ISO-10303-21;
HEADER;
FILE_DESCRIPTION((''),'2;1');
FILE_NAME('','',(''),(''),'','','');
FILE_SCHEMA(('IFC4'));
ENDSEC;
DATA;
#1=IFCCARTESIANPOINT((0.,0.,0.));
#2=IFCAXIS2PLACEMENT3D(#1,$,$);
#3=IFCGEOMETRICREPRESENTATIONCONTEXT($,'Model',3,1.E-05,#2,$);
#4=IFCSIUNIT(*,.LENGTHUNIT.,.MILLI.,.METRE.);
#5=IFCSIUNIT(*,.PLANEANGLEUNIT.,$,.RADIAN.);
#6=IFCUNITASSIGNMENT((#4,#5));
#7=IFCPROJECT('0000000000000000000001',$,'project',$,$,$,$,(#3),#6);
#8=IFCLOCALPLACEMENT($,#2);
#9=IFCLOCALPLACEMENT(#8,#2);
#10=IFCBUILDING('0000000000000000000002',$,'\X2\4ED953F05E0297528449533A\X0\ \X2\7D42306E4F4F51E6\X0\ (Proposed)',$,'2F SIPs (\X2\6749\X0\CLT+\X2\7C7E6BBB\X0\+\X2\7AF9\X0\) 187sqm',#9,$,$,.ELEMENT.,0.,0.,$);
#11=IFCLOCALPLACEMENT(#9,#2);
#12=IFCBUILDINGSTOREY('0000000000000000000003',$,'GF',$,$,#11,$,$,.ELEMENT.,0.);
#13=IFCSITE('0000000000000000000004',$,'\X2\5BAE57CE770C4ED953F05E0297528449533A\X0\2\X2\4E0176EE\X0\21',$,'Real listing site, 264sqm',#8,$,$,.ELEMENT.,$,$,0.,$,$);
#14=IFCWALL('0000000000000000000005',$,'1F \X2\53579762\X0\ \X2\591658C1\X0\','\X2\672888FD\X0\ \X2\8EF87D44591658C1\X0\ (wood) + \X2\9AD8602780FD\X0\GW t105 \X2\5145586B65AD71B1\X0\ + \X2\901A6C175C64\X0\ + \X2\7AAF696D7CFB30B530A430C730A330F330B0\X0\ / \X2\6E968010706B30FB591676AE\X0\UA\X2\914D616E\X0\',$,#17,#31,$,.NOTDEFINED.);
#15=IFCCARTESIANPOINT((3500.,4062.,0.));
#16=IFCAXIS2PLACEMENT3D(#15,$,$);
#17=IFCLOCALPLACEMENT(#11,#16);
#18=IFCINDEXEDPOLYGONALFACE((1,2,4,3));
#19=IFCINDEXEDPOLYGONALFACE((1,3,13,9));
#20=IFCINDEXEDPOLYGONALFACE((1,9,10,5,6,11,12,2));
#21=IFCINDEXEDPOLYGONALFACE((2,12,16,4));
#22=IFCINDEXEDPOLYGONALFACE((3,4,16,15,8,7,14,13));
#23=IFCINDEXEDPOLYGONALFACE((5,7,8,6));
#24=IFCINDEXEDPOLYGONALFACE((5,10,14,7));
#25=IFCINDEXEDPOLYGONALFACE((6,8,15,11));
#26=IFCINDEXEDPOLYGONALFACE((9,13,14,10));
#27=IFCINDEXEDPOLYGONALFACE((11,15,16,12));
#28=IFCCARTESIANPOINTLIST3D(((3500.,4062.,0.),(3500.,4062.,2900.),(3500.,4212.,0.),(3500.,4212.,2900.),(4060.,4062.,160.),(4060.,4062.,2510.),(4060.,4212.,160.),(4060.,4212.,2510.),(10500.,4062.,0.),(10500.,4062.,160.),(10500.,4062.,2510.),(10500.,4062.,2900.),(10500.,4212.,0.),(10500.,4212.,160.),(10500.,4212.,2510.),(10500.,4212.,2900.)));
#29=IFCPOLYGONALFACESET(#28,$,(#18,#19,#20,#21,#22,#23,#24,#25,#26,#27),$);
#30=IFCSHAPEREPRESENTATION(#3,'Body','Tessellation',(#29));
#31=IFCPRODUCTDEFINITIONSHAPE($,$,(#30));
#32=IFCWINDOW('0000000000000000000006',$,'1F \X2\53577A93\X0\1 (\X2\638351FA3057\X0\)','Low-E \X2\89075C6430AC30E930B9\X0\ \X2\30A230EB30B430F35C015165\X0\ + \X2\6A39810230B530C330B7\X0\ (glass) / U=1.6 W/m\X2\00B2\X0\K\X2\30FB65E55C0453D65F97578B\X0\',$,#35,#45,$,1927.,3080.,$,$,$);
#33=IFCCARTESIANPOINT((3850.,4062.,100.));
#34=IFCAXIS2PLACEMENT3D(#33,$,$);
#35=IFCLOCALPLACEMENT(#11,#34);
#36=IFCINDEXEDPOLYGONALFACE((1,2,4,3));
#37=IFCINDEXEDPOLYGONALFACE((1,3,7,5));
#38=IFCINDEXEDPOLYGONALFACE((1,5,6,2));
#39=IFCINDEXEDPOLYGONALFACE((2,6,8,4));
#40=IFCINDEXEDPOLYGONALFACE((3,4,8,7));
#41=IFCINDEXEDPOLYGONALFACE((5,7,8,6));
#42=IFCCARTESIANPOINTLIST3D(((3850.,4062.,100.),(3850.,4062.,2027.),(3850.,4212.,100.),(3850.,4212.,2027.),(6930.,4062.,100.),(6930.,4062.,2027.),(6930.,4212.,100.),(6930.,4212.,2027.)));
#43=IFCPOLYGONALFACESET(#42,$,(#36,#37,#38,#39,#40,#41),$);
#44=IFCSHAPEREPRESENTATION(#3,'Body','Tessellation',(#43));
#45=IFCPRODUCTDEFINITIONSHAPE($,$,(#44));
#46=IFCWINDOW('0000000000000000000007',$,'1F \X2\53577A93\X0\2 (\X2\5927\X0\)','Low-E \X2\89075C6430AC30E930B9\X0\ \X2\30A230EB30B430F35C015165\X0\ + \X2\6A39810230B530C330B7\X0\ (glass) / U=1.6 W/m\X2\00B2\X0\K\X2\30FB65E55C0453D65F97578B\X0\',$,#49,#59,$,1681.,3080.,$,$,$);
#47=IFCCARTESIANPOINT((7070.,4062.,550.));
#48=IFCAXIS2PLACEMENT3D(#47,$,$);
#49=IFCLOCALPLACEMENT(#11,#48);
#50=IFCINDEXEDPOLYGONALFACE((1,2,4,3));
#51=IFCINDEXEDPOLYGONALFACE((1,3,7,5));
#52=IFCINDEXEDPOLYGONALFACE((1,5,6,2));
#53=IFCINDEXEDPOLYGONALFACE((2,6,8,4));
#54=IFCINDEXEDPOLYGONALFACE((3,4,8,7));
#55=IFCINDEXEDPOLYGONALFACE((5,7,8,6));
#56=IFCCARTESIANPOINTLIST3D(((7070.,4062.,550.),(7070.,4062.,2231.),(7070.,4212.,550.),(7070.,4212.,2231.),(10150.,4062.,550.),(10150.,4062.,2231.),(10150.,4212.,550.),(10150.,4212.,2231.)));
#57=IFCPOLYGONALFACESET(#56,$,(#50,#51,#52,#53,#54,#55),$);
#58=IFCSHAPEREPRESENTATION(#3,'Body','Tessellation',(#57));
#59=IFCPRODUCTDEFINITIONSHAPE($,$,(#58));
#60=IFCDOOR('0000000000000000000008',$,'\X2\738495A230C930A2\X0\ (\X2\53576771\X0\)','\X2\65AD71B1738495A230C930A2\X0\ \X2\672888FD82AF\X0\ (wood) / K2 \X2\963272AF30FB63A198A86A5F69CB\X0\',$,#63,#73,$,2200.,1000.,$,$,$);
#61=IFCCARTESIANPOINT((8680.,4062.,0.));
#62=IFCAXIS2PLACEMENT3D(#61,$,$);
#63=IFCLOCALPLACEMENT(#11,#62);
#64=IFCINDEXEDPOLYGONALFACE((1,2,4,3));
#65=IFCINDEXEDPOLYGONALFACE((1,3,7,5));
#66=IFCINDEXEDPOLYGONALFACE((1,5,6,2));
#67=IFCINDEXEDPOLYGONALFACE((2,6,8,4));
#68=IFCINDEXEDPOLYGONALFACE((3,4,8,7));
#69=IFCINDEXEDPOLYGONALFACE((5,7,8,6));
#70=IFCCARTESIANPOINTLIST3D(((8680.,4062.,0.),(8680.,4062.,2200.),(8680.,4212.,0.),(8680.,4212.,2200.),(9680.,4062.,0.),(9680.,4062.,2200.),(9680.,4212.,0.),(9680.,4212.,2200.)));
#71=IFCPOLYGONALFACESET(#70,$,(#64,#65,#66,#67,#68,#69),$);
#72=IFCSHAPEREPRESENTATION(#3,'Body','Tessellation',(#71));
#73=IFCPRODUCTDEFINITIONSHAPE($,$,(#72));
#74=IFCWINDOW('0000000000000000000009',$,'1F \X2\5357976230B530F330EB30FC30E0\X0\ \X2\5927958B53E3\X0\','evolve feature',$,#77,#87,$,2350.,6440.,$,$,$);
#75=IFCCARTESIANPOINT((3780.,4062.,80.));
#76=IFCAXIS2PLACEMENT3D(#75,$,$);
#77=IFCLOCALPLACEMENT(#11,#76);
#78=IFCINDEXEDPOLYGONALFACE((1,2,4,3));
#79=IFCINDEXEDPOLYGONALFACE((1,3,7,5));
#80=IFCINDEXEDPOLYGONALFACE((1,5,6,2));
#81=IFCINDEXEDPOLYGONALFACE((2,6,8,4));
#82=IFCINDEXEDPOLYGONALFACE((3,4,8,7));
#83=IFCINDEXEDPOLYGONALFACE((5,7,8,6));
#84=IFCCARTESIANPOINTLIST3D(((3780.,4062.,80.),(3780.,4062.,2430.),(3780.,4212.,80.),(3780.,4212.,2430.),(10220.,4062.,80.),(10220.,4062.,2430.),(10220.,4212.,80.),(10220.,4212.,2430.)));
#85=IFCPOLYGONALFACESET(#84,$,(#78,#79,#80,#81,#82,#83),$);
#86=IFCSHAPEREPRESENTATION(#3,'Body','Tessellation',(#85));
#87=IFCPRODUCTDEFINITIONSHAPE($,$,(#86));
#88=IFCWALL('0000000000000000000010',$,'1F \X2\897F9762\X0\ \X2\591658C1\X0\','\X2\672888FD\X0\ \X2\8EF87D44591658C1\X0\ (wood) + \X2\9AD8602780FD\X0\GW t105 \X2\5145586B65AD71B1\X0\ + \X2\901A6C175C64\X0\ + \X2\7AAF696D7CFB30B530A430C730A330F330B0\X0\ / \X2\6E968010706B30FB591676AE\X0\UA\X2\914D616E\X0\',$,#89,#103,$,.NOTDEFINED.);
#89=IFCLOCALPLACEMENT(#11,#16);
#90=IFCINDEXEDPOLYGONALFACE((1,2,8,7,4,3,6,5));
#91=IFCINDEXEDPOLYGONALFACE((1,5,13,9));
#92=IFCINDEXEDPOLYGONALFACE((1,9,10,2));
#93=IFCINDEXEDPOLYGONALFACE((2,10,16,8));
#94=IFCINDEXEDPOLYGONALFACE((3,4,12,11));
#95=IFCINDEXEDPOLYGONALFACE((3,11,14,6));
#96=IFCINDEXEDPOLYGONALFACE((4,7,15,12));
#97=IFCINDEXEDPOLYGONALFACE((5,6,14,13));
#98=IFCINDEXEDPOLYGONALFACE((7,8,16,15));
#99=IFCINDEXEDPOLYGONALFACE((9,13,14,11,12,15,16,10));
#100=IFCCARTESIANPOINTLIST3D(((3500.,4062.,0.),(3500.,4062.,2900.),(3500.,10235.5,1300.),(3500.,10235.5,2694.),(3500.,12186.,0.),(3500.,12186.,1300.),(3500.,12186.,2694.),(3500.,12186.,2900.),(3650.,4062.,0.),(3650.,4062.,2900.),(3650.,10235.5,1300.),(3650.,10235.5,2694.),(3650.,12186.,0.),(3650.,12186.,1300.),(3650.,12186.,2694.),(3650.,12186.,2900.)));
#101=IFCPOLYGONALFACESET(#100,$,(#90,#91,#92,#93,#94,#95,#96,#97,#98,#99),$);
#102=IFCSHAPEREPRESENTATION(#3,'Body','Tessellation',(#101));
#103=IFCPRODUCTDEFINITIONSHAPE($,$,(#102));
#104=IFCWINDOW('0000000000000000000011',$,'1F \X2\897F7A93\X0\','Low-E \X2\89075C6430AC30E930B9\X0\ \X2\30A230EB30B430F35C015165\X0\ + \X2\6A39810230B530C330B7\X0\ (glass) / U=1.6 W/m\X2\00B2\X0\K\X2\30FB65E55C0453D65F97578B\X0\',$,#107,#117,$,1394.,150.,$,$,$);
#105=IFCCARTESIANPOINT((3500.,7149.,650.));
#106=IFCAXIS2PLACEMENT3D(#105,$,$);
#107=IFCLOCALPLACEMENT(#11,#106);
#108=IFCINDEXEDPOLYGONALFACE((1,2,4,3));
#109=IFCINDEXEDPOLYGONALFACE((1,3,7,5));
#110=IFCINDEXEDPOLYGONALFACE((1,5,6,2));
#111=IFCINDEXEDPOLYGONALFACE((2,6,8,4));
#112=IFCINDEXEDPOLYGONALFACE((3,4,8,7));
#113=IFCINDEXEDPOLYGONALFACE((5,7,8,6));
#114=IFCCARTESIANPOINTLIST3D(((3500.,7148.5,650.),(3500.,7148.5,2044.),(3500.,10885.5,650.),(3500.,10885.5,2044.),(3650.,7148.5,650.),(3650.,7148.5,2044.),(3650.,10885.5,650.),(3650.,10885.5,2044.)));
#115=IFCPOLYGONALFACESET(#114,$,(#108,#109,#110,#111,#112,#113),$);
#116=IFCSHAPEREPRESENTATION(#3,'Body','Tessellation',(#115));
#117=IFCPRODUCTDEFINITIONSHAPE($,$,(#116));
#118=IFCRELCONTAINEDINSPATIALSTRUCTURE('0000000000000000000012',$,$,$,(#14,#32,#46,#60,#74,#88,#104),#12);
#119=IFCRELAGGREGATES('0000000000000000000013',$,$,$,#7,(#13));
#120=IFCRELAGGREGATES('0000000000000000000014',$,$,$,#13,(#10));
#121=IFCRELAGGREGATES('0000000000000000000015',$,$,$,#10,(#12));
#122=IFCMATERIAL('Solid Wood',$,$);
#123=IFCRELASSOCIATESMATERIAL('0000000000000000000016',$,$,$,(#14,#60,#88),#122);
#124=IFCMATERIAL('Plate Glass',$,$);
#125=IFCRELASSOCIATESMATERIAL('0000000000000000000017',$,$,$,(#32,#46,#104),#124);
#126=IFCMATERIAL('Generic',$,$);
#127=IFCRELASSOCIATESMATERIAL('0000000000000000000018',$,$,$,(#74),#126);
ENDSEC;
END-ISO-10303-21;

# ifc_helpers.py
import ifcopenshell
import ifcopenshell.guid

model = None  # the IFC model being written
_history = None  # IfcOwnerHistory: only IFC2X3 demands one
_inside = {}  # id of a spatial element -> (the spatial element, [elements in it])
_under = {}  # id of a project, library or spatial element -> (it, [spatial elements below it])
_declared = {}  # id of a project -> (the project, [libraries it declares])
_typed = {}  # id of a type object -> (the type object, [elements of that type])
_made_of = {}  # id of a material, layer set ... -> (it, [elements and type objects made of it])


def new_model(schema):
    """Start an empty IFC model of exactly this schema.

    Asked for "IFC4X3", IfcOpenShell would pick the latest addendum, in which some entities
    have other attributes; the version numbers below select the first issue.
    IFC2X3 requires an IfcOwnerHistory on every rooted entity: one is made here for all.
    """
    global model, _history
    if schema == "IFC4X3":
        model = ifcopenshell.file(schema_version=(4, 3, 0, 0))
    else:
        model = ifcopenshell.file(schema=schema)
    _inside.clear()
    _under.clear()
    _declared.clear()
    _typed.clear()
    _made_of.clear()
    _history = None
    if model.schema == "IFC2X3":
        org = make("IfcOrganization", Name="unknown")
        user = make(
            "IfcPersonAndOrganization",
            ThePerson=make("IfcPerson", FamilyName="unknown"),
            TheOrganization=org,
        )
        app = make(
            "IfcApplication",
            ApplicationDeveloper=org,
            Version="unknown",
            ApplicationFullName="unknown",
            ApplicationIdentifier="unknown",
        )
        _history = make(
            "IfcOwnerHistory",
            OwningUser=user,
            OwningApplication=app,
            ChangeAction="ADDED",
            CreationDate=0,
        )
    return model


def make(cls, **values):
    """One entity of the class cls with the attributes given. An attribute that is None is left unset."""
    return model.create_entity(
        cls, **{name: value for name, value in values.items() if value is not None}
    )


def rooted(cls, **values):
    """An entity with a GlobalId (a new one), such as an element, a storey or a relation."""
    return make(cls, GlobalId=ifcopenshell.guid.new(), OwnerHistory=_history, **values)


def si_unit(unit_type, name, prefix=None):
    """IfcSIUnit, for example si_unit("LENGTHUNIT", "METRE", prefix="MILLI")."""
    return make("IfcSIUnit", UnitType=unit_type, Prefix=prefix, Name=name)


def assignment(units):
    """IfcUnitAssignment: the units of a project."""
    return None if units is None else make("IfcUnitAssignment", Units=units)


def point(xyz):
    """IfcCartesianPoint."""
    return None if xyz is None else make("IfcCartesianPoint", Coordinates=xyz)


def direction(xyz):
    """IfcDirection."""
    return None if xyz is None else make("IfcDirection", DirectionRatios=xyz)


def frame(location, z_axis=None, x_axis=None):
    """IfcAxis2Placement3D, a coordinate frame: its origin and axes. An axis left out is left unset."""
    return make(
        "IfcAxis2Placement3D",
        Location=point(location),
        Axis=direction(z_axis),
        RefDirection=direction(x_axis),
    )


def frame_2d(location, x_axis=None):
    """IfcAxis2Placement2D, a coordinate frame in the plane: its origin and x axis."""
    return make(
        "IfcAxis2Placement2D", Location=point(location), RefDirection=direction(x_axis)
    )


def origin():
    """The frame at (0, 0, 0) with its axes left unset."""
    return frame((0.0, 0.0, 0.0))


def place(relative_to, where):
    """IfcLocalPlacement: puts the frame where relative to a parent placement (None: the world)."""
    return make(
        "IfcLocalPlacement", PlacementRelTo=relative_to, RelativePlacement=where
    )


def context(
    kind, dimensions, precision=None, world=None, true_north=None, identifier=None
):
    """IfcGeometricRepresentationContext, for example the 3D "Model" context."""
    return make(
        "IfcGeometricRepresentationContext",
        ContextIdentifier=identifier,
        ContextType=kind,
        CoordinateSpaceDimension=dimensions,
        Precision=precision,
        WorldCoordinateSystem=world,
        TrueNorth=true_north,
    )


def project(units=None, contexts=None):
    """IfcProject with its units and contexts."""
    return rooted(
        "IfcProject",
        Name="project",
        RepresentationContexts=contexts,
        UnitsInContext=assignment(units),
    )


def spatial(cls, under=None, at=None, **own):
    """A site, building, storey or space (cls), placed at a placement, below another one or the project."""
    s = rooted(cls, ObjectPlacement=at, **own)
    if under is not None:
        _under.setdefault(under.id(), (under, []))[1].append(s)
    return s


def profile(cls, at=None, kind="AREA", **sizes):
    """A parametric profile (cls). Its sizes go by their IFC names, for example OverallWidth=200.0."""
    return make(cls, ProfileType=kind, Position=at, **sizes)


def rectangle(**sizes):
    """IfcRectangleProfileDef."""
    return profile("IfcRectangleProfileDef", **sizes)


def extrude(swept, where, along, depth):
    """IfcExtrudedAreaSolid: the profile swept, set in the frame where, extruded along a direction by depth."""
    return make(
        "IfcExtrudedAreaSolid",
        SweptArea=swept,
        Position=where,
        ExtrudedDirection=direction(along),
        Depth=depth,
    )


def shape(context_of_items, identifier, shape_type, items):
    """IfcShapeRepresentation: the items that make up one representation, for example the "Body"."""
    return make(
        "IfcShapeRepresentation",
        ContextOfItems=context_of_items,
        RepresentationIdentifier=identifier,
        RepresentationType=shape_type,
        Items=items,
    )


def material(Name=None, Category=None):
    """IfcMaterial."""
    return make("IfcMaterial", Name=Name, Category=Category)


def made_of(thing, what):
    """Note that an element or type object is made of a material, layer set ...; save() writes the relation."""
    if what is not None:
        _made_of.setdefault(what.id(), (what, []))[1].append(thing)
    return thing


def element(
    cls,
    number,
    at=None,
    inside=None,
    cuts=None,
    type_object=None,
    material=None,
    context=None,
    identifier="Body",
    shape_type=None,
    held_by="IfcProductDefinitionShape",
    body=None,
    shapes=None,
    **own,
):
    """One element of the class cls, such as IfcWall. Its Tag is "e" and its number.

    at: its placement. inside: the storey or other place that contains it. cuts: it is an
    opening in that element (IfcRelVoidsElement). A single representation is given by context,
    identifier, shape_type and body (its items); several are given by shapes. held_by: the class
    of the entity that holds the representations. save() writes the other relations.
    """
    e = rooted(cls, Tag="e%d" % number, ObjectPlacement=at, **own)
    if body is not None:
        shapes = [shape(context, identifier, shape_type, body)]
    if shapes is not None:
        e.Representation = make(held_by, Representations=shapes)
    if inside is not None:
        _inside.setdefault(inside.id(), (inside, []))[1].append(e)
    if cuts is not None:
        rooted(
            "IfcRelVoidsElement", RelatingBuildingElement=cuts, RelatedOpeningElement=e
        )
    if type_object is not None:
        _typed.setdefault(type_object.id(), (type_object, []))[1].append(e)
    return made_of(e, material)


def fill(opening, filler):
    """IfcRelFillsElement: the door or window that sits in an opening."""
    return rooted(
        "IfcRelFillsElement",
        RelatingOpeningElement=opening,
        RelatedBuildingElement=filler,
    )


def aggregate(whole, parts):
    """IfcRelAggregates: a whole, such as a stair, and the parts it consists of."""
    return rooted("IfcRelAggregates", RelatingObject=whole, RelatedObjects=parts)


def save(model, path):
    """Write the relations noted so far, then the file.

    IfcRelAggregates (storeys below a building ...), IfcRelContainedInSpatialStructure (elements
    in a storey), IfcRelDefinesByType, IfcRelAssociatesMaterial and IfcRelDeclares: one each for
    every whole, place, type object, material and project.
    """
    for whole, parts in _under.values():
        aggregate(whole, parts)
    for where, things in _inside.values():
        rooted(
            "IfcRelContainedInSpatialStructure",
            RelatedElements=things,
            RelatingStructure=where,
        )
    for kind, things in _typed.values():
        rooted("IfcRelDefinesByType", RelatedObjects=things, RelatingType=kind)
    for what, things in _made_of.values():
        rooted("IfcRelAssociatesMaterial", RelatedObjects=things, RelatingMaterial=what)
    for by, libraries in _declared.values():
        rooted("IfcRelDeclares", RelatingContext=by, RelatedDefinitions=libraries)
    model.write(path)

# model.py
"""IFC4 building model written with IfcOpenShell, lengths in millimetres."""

from ifc_helpers import new_model, si_unit, frame, frame_2d, origin, place, context, project, spatial, rectangle, extrude, material, element, fill, save


model = new_model("IFC4")

# Units and contexts
model_context = context("Model", 3, precision=1e-05, world=origin())
ifc_project = project(units=[si_unit("LENGTHUNIT", "METRE", prefix="MILLI"), si_unit("PLANEANGLEUNIT", "RADIAN")], contexts=[model_context])

# Site, building, storey
site_placement = place(None, origin())
site = spatial("IfcSite", under=ifc_project, at=site_placement, Name="宮城県仙台市青葉区2丁目21", ObjectType="Real listing site, 264sqm", CompositionType="ELEMENT", RefElevation=0.0)
building_placement = place(site_placement, origin())
building = spatial("IfcBuilding", under=site, at=building_placement, Name="仙台市青葉区 終の住処 (Proposed)", ObjectType="2F SIPs (杉CLT+籾殻+竹) 187sqm", CompositionType="ELEMENT", ElevationOfRefHeight=0.0, ElevationOfTerrain=0.0)
storey_placement = place(building_placement, origin())
storey = spatial("IfcBuildingStorey", under=building, at=storey_placement, Name="GF", CompositionType="ELEMENT", Elevation=0.0)

# Shared definitions
ifc_material_1 = material(Name="Solid Wood")
ifc_material_2 = material(Name="Generic")

# Wall, openings, windows, door
wall_1_placement = place(storey_placement, frame((3500.0, 4062.0, 0.0)))
wall_1 = element("IfcWall", 1, at=wall_1_placement, inside=storey, material=ifc_material_1, Name="1F 南面 外壁", Description="木製 軸組外壁 (wood) + 高性能GW t105 充填断熱 + 通気層 + 窯業系サイディング / 準耐火・外皮UA配慮", PredefinedType="NOTDEFINED", context=model_context, shape_type="SweptSolid", body=[
    extrude(rectangle(XDim=7000.0, YDim=150.0, at=frame_2d((3500.0, 75.0))), frame((3500.0, 4062.0, 0.0)), (0.0, 0.0, 1.0), 2900.0),
])
opening_1_placement = place(storey_placement, frame((3850.0, 4062.0, 100.0)))
opening_1 = element("IfcOpeningElement", 2, at=opening_1_placement, cuts=wall_1, PredefinedType="NOTDEFINED", context=model_context, shape_type="SweptSolid", body=[
    extrude(rectangle(XDim=3080.0, YDim=150.0, at=frame_2d((1540.0, 75.0))), frame((3850.0, 4062.0, 100.0)), (0.0, 0.0, 1.0), 1927.0),
])
opening_2_placement = place(storey_placement, frame((7070.0, 4062.0, 550.0)))
opening_2 = element("IfcOpeningElement", 3, at=opening_2_placement, cuts=wall_1, PredefinedType="NOTDEFINED", context=model_context, shape_type="SweptSolid", body=[
    extrude(rectangle(XDim=3080.0, YDim=150.0, at=frame_2d((1540.0, 75.0))), frame((7070.0, 4062.0, 550.0)), (0.0, 0.0, 1.0), 1681.0),
])
opening_3_placement = place(storey_placement, frame((8680.0, 4062.0, 0.0)))
opening_3 = element("IfcOpeningElement", 4, at=opening_3_placement, cuts=wall_1, PredefinedType="NOTDEFINED", context=model_context, shape_type="SweptSolid", body=[
    extrude(rectangle(XDim=1000.0, YDim=150.0, at=frame_2d((500.0, 75.0))), frame((8680.0, 4062.0, 0.0)), (0.0, 0.0, 1.0), 2200.0),
])
opening_4_placement = place(storey_placement, frame((3780.0, 4062.0, 80.0)))
opening_4 = element("IfcOpeningElement", 5, at=opening_4_placement, cuts=wall_1, PredefinedType="NOTDEFINED", context=model_context, shape_type="SweptSolid", body=[
    extrude(rectangle(XDim=6440.0, YDim=150.0, at=frame_2d((3220.0, 75.0))), frame((3780.0, 4062.0, 80.0)), (0.0, 0.0, 1.0), 2350.0),
])
ifc_material_3 = material(Name="Plate Glass")
window_1_placement = place(storey_placement, frame((3850.0, 4062.0, 100.0)))
window_1 = element("IfcWindow", 6, at=window_1_placement, inside=storey, material=ifc_material_3, Name="1F 南窓1 (掃出し)", Description="Low-E 複層ガラス アルゴン封入 + 樹脂サッシ (glass) / U=1.6 W/m²K・日射取得型", OverallHeight=1927.0, OverallWidth=3080.0, context=model_context, shape_type="SweptSolid", body=[
    extrude(rectangle(XDim=3080.0, YDim=150.0, at=frame_2d((1540.0, 75.0))), frame((3850.0, 4062.0, 100.0)), (0.0, 0.0, 1.0), 1927.0),
])
fill(opening_1, window_1)
window_2_placement = place(storey_placement, frame((7070.0, 4062.0, 550.0)))
window_2 = element("IfcWindow", 7, at=window_2_placement, inside=storey, material=ifc_material_3, Name="1F 南窓2 (大)", Description="Low-E 複層ガラス アルゴン封入 + 樹脂サッシ (glass) / U=1.6 W/m²K・日射取得型", OverallHeight=1681.0, OverallWidth=3080.0, context=model_context, shape_type="SweptSolid", body=[
    extrude(rectangle(XDim=3080.0, YDim=150.0, at=frame_2d((1540.0, 75.0))), frame((7070.0, 4062.0, 550.0)), (0.0, 0.0, 1.0), 1681.0),
])
fill(opening_2, window_2)
door_placement = place(storey_placement, frame((8680.0, 4062.0, 0.0)))
door = element("IfcDoor", 8, at=door_placement, inside=storey, material=ifc_material_1, Name="玄関ドア (南東)", Description="断熱玄関ドア 木製芯 (wood) / K2 防犯・採風機構", OverallHeight=2200.0, OverallWidth=1000.0, context=model_context, shape_type="SweptSolid", body=[
    extrude(rectangle(XDim=1000.0, YDim=150.0, at=frame_2d((500.0, 75.0))), frame((8680.0, 4062.0, 0.0)), (0.0, 0.0, 1.0), 2200.0),
])
fill(opening_3, door)
window_3_placement = place(storey_placement, frame((3780.0, 4062.0, 80.0)))
window_3 = element("IfcWindow", 9, at=window_3_placement, inside=storey, material=ifc_material_2, Name="1F 南面サンルーム 大開口", Description="evolve feature", OverallHeight=2350.0, OverallWidth=6440.0, context=model_context, shape_type="SweptSolid", body=[
    extrude(rectangle(XDim=6440.0, YDim=150.0, at=frame_2d((3220.0, 75.0))), frame((3780.0, 4062.0, 80.0)), (0.0, 0.0, 1.0), 2350.0),
])
fill(opening_4, window_3)

# Wall, opening, window
wall_2_placement = place(storey_placement, frame((3500.0, 4062.0, 0.0)))
wall_2 = element("IfcWall", 10, at=wall_2_placement, inside=storey, material=ifc_material_1, Name="1F 西面 外壁", Description="木製 軸組外壁 (wood) + 高性能GW t105 充填断熱 + 通気層 + 窯業系サイディング / 準耐火・外皮UA配慮", PredefinedType="NOTDEFINED", context=model_context, shape_type="SweptSolid", body=[
    extrude(rectangle(XDim=150.0, YDim=8124.0, at=frame_2d((75.0, 4062.0))), frame((3500.0, 4062.0, 0.0)), (0.0, 0.0, 1.0), 2900.0),
])
opening_5_placement = place(storey_placement, frame((3500.0, 7149.0, 650.0)))
opening_5 = element("IfcOpeningElement", 11, at=opening_5_placement, cuts=wall_2, PredefinedType="NOTDEFINED", context=model_context, shape_type="SweptSolid", body=[
    extrude(rectangle(XDim=150.0, YDim=3737.0, at=frame_2d((75.0, 1868.0))), frame((3500.0, 7149.0, 650.0)), (0.0, 0.0, 1.0), 1394.0),
])
window_4_placement = place(storey_placement, frame((3500.0, 7149.0, 650.0)))
window_4 = element("IfcWindow", 12, at=window_4_placement, inside=storey, material=ifc_material_3, Name="1F 西窓", Description="Low-E 複層ガラス アルゴン封入 + 樹脂サッシ (glass) / U=1.6 W/m²K・日射取得型", OverallHeight=1394.0, OverallWidth=150.0, context=model_context, shape_type="SweptSolid", body=[
    extrude(rectangle(XDim=150.0, YDim=3737.0, at=frame_2d((75.0, 1868.0))), frame((3500.0, 7149.0, 650.0)), (0.0, 0.0, 1.0), 1394.0),
])
fill(opening_5, window_4)

save(model, "model.ifc")
